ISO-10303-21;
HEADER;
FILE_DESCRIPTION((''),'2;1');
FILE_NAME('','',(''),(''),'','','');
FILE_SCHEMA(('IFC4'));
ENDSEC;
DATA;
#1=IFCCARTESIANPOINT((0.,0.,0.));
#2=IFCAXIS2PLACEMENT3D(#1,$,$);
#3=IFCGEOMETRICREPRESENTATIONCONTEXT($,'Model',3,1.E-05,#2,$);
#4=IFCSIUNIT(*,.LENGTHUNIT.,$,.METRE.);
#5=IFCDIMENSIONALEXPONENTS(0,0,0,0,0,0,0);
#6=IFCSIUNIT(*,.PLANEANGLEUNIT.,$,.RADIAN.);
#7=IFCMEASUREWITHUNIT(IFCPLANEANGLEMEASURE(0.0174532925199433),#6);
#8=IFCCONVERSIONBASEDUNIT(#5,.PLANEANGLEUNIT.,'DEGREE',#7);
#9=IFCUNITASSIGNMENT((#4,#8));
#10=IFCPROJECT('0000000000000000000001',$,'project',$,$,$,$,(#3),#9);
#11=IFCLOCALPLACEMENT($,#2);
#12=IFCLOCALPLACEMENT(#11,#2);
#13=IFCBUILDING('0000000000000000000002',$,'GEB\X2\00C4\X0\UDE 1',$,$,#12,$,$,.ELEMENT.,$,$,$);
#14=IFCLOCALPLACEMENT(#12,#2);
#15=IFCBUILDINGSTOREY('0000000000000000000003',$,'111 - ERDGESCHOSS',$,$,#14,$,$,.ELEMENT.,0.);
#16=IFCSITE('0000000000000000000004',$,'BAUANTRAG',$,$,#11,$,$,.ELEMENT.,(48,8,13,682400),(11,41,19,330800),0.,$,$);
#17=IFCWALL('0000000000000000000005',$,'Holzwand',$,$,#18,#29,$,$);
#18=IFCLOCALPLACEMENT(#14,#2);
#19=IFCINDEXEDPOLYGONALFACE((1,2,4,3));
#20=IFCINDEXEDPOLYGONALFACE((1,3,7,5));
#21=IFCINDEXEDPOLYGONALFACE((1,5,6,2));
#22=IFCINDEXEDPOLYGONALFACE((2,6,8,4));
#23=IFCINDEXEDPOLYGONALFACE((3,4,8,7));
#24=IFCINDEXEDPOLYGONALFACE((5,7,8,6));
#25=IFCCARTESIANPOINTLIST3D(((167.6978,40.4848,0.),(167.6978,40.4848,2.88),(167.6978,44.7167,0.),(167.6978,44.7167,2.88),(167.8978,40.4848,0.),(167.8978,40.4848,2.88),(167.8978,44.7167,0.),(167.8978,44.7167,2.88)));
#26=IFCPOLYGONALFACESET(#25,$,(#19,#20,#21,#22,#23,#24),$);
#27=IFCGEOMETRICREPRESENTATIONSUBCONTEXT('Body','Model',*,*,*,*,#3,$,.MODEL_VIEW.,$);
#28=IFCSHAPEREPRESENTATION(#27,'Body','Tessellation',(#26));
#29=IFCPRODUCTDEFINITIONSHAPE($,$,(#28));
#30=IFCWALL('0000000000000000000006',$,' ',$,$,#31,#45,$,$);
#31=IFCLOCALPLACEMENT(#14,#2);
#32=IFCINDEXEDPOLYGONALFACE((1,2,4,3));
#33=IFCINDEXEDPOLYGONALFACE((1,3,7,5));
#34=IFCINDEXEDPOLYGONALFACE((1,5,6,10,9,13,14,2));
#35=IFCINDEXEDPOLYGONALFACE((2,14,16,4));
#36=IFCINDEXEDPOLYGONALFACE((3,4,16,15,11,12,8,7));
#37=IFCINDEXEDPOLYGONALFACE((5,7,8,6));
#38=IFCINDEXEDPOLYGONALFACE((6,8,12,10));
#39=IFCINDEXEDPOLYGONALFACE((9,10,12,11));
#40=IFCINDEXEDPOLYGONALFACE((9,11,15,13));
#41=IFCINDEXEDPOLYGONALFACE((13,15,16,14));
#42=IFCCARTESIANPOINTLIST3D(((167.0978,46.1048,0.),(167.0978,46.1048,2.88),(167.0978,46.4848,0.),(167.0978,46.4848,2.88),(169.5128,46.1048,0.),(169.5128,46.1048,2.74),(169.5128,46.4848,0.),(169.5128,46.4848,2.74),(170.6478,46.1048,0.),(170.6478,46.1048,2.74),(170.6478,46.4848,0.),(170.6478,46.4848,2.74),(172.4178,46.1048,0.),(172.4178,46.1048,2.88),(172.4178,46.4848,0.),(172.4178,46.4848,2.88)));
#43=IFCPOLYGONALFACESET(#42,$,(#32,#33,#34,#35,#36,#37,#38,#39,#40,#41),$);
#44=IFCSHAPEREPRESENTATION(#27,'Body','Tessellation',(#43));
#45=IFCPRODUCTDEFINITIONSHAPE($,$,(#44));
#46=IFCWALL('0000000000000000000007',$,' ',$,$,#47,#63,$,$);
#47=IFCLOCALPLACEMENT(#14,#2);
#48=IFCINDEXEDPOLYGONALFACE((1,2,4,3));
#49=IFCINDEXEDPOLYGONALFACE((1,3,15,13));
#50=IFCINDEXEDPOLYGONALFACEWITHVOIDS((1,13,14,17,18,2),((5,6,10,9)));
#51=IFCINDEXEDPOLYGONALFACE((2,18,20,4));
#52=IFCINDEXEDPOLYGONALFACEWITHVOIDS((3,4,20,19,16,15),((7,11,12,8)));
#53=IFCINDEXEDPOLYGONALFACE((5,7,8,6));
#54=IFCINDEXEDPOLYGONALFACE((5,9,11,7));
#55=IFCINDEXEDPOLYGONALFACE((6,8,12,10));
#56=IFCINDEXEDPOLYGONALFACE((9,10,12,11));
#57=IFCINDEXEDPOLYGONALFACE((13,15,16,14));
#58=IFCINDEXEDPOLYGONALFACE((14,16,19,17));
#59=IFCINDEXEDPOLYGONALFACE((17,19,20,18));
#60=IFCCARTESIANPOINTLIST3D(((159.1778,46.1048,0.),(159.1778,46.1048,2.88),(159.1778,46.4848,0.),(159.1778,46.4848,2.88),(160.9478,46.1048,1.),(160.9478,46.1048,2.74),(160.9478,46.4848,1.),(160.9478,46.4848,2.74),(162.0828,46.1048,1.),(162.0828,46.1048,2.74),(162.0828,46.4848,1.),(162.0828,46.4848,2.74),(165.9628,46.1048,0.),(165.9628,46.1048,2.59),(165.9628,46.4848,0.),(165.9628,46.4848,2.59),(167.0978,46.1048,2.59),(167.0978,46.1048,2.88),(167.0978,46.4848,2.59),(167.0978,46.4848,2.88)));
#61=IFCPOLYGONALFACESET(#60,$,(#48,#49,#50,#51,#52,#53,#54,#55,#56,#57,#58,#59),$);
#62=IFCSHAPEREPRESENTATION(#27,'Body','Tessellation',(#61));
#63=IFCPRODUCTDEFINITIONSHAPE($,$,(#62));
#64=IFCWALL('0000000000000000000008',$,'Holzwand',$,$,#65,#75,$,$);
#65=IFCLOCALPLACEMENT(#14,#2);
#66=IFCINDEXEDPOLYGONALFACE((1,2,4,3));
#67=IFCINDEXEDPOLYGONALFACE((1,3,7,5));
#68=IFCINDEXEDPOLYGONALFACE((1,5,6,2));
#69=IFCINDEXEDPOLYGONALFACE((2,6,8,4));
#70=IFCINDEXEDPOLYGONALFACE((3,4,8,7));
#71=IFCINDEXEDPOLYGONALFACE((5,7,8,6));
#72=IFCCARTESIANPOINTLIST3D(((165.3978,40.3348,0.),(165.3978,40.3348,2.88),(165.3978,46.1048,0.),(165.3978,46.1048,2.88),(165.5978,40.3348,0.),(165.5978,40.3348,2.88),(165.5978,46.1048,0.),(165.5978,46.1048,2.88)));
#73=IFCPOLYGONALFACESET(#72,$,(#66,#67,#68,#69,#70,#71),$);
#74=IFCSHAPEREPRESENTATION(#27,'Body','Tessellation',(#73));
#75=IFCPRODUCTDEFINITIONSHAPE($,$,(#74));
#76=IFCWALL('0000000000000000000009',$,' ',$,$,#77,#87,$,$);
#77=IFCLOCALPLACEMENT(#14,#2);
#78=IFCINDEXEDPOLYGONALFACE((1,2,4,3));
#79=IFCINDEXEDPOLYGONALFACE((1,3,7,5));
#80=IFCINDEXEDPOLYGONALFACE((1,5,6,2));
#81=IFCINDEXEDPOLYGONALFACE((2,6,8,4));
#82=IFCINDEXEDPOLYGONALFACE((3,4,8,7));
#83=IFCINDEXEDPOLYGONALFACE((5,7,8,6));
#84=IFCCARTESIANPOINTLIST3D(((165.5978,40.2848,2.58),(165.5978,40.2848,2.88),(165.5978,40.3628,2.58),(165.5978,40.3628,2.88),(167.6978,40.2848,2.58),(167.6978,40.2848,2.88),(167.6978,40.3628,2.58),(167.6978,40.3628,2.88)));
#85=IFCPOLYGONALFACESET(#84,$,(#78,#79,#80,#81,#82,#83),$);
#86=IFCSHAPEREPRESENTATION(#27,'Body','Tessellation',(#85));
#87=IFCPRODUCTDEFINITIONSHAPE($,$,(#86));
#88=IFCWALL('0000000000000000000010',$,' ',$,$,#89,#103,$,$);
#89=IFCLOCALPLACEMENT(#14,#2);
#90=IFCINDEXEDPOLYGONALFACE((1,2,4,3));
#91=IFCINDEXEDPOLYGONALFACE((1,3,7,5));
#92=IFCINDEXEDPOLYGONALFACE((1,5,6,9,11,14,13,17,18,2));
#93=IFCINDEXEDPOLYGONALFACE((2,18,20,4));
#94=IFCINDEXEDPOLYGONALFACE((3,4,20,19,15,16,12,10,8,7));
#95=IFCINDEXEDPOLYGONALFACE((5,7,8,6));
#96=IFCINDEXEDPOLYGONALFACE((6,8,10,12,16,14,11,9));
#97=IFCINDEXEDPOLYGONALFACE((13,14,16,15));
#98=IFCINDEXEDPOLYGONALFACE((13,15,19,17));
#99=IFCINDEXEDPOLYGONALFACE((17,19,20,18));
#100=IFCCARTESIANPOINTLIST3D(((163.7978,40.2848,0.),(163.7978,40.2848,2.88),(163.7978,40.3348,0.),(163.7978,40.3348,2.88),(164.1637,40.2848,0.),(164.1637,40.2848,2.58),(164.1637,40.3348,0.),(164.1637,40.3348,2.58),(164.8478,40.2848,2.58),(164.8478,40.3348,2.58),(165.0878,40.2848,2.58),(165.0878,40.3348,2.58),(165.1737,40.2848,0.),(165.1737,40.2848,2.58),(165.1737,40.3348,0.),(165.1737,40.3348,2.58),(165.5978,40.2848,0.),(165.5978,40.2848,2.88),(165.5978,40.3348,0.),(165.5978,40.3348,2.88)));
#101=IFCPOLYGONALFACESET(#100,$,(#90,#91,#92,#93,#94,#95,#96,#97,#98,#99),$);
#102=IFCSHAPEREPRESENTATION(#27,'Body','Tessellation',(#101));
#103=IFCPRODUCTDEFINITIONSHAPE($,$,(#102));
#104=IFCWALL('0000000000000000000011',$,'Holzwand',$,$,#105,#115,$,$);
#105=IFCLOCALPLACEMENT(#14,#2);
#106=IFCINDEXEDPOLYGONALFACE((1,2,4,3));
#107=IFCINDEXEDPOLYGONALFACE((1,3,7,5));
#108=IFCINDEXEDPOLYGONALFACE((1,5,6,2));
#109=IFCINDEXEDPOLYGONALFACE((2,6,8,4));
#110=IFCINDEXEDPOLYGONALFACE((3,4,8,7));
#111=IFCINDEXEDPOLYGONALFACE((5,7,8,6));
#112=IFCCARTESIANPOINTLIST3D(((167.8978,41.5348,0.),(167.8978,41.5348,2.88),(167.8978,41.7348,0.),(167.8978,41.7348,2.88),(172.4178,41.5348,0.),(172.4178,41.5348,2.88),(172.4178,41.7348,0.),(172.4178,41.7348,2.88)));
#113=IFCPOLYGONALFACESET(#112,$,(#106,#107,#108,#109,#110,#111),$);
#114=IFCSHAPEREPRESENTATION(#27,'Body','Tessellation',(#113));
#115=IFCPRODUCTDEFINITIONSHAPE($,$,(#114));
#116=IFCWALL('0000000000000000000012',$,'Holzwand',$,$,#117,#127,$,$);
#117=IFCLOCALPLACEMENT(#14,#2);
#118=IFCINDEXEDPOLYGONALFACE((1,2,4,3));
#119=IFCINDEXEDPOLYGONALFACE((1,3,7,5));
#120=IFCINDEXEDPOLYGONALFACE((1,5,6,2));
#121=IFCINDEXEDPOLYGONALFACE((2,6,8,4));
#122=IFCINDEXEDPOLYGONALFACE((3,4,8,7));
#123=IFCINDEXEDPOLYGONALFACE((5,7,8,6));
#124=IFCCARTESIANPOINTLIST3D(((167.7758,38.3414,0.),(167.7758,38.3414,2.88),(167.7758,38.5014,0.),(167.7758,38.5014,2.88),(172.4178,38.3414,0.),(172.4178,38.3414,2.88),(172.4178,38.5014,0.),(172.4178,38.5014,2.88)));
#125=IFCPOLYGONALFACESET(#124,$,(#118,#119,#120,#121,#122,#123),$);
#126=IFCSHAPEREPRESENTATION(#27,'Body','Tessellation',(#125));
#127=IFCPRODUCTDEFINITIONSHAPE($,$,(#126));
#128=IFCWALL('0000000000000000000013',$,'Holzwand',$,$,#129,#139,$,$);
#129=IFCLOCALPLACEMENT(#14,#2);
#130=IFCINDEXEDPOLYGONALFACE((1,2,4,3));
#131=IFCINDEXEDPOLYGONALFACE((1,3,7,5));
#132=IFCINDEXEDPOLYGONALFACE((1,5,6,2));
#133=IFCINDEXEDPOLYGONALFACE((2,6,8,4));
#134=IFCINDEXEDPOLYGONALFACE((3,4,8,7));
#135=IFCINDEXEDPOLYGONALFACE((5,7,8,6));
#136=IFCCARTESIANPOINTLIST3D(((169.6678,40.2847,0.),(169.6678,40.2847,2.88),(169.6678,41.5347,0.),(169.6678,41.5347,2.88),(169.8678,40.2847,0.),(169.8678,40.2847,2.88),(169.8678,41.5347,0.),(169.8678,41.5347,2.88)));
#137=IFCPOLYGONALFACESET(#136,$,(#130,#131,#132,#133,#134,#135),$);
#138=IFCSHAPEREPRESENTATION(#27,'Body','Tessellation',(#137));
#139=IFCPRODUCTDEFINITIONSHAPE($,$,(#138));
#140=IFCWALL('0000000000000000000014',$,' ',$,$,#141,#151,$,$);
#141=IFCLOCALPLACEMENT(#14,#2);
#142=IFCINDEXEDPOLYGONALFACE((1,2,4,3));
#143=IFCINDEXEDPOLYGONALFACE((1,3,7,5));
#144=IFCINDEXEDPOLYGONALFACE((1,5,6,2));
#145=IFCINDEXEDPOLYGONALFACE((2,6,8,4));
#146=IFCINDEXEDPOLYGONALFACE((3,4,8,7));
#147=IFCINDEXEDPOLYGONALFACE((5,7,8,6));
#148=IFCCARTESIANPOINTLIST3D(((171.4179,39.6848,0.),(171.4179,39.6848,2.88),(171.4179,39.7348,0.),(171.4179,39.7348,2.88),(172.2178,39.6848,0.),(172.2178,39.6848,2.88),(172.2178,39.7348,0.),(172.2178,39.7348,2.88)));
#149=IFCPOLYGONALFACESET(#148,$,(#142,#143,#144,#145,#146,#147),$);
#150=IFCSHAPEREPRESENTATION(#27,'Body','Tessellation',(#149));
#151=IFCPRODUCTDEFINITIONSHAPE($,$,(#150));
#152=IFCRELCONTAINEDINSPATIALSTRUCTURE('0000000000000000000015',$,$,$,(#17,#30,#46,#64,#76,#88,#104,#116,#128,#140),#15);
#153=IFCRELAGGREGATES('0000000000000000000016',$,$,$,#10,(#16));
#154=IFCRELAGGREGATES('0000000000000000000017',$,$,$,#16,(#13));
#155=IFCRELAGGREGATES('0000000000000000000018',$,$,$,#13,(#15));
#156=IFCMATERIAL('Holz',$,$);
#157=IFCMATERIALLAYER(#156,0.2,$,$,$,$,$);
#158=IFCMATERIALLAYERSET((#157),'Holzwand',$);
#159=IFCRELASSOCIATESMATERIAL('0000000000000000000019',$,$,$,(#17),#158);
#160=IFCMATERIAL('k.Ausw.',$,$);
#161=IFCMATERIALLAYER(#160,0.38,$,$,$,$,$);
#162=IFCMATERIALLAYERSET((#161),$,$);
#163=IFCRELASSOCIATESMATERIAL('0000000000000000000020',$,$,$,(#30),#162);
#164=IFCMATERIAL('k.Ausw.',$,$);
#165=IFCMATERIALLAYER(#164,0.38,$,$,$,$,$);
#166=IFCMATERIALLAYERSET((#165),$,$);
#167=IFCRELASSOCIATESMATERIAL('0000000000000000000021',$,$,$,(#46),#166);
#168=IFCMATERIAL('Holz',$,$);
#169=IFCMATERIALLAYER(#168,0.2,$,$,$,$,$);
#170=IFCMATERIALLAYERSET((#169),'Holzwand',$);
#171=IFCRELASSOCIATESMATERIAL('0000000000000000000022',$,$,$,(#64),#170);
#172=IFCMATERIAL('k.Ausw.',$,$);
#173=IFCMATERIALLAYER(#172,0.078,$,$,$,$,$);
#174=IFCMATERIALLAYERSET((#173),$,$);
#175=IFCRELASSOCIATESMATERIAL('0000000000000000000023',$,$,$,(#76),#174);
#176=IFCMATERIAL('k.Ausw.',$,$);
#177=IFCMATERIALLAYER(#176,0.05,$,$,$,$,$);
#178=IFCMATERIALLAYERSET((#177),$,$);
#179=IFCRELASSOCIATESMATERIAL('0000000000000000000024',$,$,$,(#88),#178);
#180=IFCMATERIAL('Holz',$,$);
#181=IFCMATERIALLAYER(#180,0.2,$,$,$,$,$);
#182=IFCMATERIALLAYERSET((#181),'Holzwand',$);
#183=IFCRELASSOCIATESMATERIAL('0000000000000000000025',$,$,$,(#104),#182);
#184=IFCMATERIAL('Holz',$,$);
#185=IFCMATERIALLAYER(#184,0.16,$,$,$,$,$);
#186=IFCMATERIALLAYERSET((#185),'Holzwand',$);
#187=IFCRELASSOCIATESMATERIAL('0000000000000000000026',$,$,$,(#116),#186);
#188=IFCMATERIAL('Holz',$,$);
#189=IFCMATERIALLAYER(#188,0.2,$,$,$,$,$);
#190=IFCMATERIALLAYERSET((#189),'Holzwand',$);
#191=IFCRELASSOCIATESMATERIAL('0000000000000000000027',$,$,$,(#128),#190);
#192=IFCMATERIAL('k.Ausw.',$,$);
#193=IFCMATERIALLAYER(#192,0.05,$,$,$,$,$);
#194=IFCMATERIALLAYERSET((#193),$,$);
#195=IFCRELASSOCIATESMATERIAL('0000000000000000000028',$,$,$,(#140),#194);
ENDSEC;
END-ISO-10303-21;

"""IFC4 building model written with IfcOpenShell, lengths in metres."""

from ifc_helpers import new_model, entity, si_unit, converted_unit, frame, frame_2d, origin, origin_with_axes, place, context, subcontext, project, spatial, polyline, rectangle, outline, extrude, material, layer, layer_set, layer_usage, element, save


model = new_model("IFC4")

# Units and contexts
model_context = context("Model", 3, precision=1e-05, world=origin())
body_context = subcontext(model_context, "Body", "Model", "MODEL_VIEW")
ifc_project = project(units=[si_unit("LENGTHUNIT", "METRE"), converted_unit("PLANEANGLEUNIT", "DEGREE", entity("IfcPlaneAngleMeasure", 0.0174532925199433), si_unit("PLANEANGLEUNIT", "RADIAN"), dimensions=[0, 0, 0, 0, 0, 0, 0])], contexts=[model_context])

# Site, building, storey
site_placement = place(None, origin())
site = spatial("IfcSite", under=ifc_project, at=site_placement, Name="BAUANTRAG", CompositionType="ELEMENT", RefLatitude=(48, 8, 13, 682400), RefLongitude=(11, 41, 19, 330800), RefElevation=0.0)
building_placement = place(site_placement, origin())
building = spatial("IfcBuilding", under=site, at=building_placement, Name="GEBÄUDE 1", CompositionType="ELEMENT")
storey_placement = place(building_placement, origin())
storey = spatial("IfcBuildingStorey", under=building, at=storey_placement, Name="111 - ERDGESCHOSS", CompositionType="ELEMENT", Elevation=0.0)

# Wall
ifc_material_1 = material(Name="Holz")
ifc_layer_1 = layer(ifc_material_1, 0.2)
ifc_layer_set_1 = layer_set([ifc_layer_1], Name="Holzwand")
ifc_layer_usage_1 = layer_usage(ifc_layer_set_1, "AXIS2", "POSITIVE", 0.0)
wall_1_placement = place(storey_placement, frame((167.6978, 44.7167, 0.0), z_axis=(0.0, 0.0, 1.0), x_axis=(0.0, -1.0, 0.0)))
element("IfcWall", 1, at=wall_1_placement, inside=storey, material=ifc_layer_usage_1, Name="Holzwand", context=body_context, shape_type="SweptSolid", body=[
    extrude(rectangle(XDim=4.2319, YDim=0.2, at=frame_2d((2.1159, 0.1), x_axis=(1.0, 0.0))), origin_with_axes(), (0.0, 0.0, 1.0), 2.88),
])

# Wall, opening
ifc_material_2 = material(Name="k.Ausw.")
ifc_layer_2 = layer(ifc_material_2, 0.38)
ifc_layer_set_2 = layer_set([ifc_layer_2])
ifc_layer_usage_2 = layer_usage(ifc_layer_set_2, "AXIS2", "POSITIVE", 0.0)
wall_2_placement = place(storey_placement, frame((172.4178, 46.4848, 0.0), z_axis=(0.0, 0.0, 1.0), x_axis=(-1.0, 0.0, 0.0)))
wall_2 = element("IfcWall", 2, at=wall_2_placement, inside=storey, material=ifc_layer_usage_2, Name=" ", context=body_context, shape_type="SweptSolid", body=[
    extrude(rectangle(XDim=5.32, YDim=0.38, at=frame_2d((2.66, 0.19), x_axis=(1.0, 0.0))), origin_with_axes(), (0.0, 0.0, 1.0), 2.88),
])
opening_1_placement = place(wall_2_placement, frame((2.905, 0.38, 0.0), z_axis=(0.0, -1.0, 0.0), x_axis=(0.0, 0.0, 1.0)))
element("IfcOpeningElement", 3, at=opening_1_placement, cuts=wall_2, ObjectType="Opening", context=body_context, shape_type="SweptSolid", body=[
    extrude(outline(polyline([(0.0, 1.135), (2.74, 1.135), (2.74, 0.0), (0.0, 0.0), (0.0, 1.135)])), origin_with_axes(), (0.0, 0.0, 1.0), 0.38),
])

# Wall, openings
ifc_material_3 = material(Name="k.Ausw.")
ifc_layer_3 = layer(ifc_material_3, 0.38)
ifc_layer_set_3 = layer_set([ifc_layer_3])
ifc_layer_usage_3 = layer_usage(ifc_layer_set_3, "AXIS2", "POSITIVE", 0.0)
wall_3_placement = place(storey_placement, frame((167.0978, 46.4848, 0.0), z_axis=(0.0, 0.0, 1.0), x_axis=(-1.0, 0.0, 0.0)))
wall_3 = element("IfcWall", 4, at=wall_3_placement, inside=storey, material=ifc_layer_usage_3, Name=" ", context=body_context, shape_type="SweptSolid", body=[
    extrude(rectangle(XDim=7.92, YDim=0.38, at=frame_2d((3.96, 0.19), x_axis=(1.0, 0.0))), origin_with_axes(), (0.0, 0.0, 1.0), 2.88),
])
opening_2_placement = place(wall_3_placement, frame((6.15, 0.38, 1.0), z_axis=(0.0, -1.0, 0.0), x_axis=(0.0, 0.0, 1.0)))
element("IfcOpeningElement", 5, at=opening_2_placement, cuts=wall_3, ObjectType="Opening", context=body_context, shape_type="SweptSolid", body=[
    extrude(outline(polyline([(0.0, 1.135), (1.74, 1.135), (1.74, 0.0), (0.0, 0.0), (0.0, 1.135)])), origin_with_axes(), (0.0, 0.0, 1.0), 0.38),
])
opening_3_placement = place(wall_3_placement, frame((0.0, 0.0, -0.15), z_axis=(0.0, 1.0, 0.0), x_axis=(0.0, 0.0, 1.0)))
element("IfcOpeningElement", 6, at=opening_3_placement, cuts=wall_3, ObjectType="Opening", context=body_context, shape_type="SweptSolid", body=[
    extrude(outline(polyline([(0.0, 1.135), (2.74, 1.135), (2.74, 0.0), (0.0, 0.0), (0.0, 1.135)])), origin_with_axes(), (0.0, 0.0, 1.0), 0.38),
])

# Wall
ifc_material_4 = material(Name="Holz")
ifc_layer_4 = layer(ifc_material_4, 0.2)
ifc_layer_set_4 = layer_set([ifc_layer_4], Name="Holzwand")
ifc_layer_usage_4 = layer_usage(ifc_layer_set_4, "AXIS2", "POSITIVE", 0.0)
wall_4_placement = place(storey_placement, frame((165.3978, 46.1048, 0.0), z_axis=(0.0, 0.0, 1.0), x_axis=(0.0, -1.0, 0.0)))
element("IfcWall", 7, at=wall_4_placement, inside=storey, material=ifc_layer_usage_4, Name="Holzwand", context=body_context, shape_type="SweptSolid", body=[
    extrude(rectangle(XDim=5.77, YDim=0.2, at=frame_2d((2.885, 0.1), x_axis=(1.0, 0.0))), origin_with_axes(), (0.0, 0.0, 1.0), 2.88),
])

# Wall, opening
ifc_material_5 = material(Name="k.Ausw.")
ifc_layer_5 = layer(ifc_material_5, 0.078)
ifc_layer_set_5 = layer_set([ifc_layer_5])
ifc_layer_usage_5 = layer_usage(ifc_layer_set_5, "AXIS2", "POSITIVE", 0.0)
wall_5_placement = place(storey_placement, frame((165.5978, 40.2848, 0.0)))
wall_5 = element("IfcWall", 8, at=wall_5_placement, inside=storey, material=ifc_layer_usage_5, Name=" ", context=body_context, shape_type="SweptSolid", body=[
    extrude(rectangle(XDim=2.1, YDim=0.078, at=frame_2d((1.05, 0.039), x_axis=(1.0, 0.0))), origin_with_axes(), (0.0, 0.0, 1.0), 2.88),
])
opening_4_placement = place(wall_5_placement, frame((0.0, 0.0, -0.14), z_axis=(0.0, 1.0, 0.0), x_axis=(0.0, 0.0, 1.0)))
element("IfcOpeningElement", 9, at=opening_4_placement, cuts=wall_5, ObjectType="Opening", context=body_context, shape_type="SweptSolid", body=[
    extrude(outline(polyline([(0.0, 2.1), (2.72, 2.1), (2.72, 0.0), (0.0, 0.0), (0.0, 2.1)])), origin_with_axes(), (0.0, 0.0, 1.0), 0.078),
])

# Wall, openings
ifc_material_6 = material(Name="k.Ausw.")
ifc_layer_6 = layer(ifc_material_6, 0.05)
ifc_layer_set_6 = layer_set([ifc_layer_6])
ifc_layer_usage_6 = layer_usage(ifc_layer_set_6, "AXIS2", "POSITIVE", 0.0)
wall_6_placement = place(storey_placement, frame((165.5978, 40.3348, 0.0), z_axis=(0.0, 0.0, 1.0), x_axis=(-1.0, 0.0, 0.0)))
wall_6 = element("IfcWall", 10, at=wall_6_placement, inside=storey, material=ifc_layer_usage_6, Name=" ", context=body_context, shape_type="SweptSolid", body=[
    extrude(rectangle(XDim=1.8, YDim=0.05, at=frame_2d((0.9, 0.025), x_axis=(1.0, 0.0))), origin_with_axes(), (0.0, 0.0, 1.0), 2.88),
])
opening_5_placement = place(wall_6_placement, frame((1.4341, 0.05, -0.14), z_axis=(0.0, -1.0, 0.0), x_axis=(0.0, 0.0, 1.0)))
element("IfcOpeningElement", 11, at=opening_5_placement, cuts=wall_6, ObjectType="Opening", context=body_context, shape_type="SweptSolid", body=[
    extrude(outline(polyline([(0.0, 1.01), (2.72, 1.01), (2.72, 0.0), (0.0, 0.0), (0.0, 1.01)])), origin_with_axes(), (0.0, 0.0, 1.0), 0.05),
])
opening_6_placement = place(wall_6_placement, frame((0.51, 0.0, -0.14), z_axis=(0.0, 1.0, 0.0), x_axis=(0.0, 0.0, 1.0)))
element("IfcOpeningElement", 12, at=opening_6_placement, cuts=wall_6, ObjectType="Opening", context=body_context, shape_type="SweptSolid", body=[
    extrude(outline(polyline([(0.0, 0.24), (2.72, 0.24), (2.72, 0.0), (0.0, 0.0), (0.0, 0.24)])), origin_with_axes(), (0.0, 0.0, 1.0), 0.05),
])

# Walls
ifc_material_7 = material(Name="Holz")
ifc_layer_7 = layer(ifc_material_7, 0.2)
ifc_layer_set_7 = layer_set([ifc_layer_7], Name="Holzwand")
ifc_layer_usage_7 = layer_usage(ifc_layer_set_7, "AXIS2", "POSITIVE", 0.0)
wall_7_placement = place(storey_placement, frame((172.4178, 41.7348, 0.0), z_axis=(0.0, 0.0, 1.0), x_axis=(-1.0, 0.0, 0.0)))
element("IfcWall", 13, at=wall_7_placement, inside=storey, material=ifc_layer_usage_7, Name="Holzwand", context=body_context, shape_type="SweptSolid", body=[
    extrude(rectangle(XDim=4.52, YDim=0.2, at=frame_2d((2.26, 0.1), x_axis=(1.0, 0.0))), origin_with_axes(), (0.0, 0.0, 1.0), 2.88),
])
ifc_material_8 = material(Name="Holz")
ifc_layer_8 = layer(ifc_material_8, 0.16)
ifc_layer_set_8 = layer_set([ifc_layer_8], Name="Holzwand")
ifc_layer_usage_8 = layer_usage(ifc_layer_set_8, "AXIS2", "POSITIVE", 0.0)
wall_8_placement = place(storey_placement, frame((172.4178, 38.5014, 0.0), z_axis=(0.0, 0.0, 1.0), x_axis=(-1.0, 0.0, 0.0)))
element("IfcWall", 14, at=wall_8_placement, inside=storey, material=ifc_layer_usage_8, Name="Holzwand", context=body_context, shape_type="SweptSolid", body=[
    extrude(rectangle(XDim=4.642, YDim=0.16, at=frame_2d((2.321, 0.08), x_axis=(1.0, 0.0))), origin_with_axes(), (0.0, 0.0, 1.0), 2.88),
])
ifc_material_9 = material(Name="Holz")
ifc_layer_9 = layer(ifc_material_9, 0.2)
ifc_layer_set_9 = layer_set([ifc_layer_9], Name="Holzwand")
ifc_layer_usage_9 = layer_usage(ifc_layer_set_9, "AXIS2", "POSITIVE", 0.0)
wall_9_placement = place(storey_placement, frame((169.8678, 40.2847, 0.0), z_axis=(0.0, 0.0, 1.0), x_axis=(0.0, 1.0, 0.0)))
element("IfcWall", 15, at=wall_9_placement, inside=storey, material=ifc_layer_usage_9, Name="Holzwand", context=body_context, shape_type="SweptSolid", body=[
    extrude(rectangle(XDim=1.25, YDim=0.2, at=frame_2d((0.625, 0.1), x_axis=(1.0, 0.0))), origin_with_axes(), (0.0, 0.0, 1.0), 2.88),
])
ifc_material_10 = material(Name="k.Ausw.")
ifc_layer_10 = layer(ifc_material_10, 0.05)
ifc_layer_set_10 = layer_set([ifc_layer_10])
ifc_layer_usage_10 = layer_usage(ifc_layer_set_10, "AXIS2", "POSITIVE", 0.0)
wall_10_placement = place(storey_placement, frame((172.2178, 39.7348, 0.0), z_axis=(0.0, 0.0, 1.0), x_axis=(-1.0, 0.0, 0.0)))
element("IfcWall", 16, at=wall_10_placement, inside=storey, material=ifc_layer_usage_10, Name=" ", context=body_context, shape_type="SweptSolid", body=[
    extrude(rectangle(XDim=0.7998, YDim=0.05, at=frame_2d((0.3999, 0.025), x_axis=(1.0, 0.0))), origin_with_axes(), (0.0, 0.0, 1.0), 2.88),
])

save(model, "model.ifc")
